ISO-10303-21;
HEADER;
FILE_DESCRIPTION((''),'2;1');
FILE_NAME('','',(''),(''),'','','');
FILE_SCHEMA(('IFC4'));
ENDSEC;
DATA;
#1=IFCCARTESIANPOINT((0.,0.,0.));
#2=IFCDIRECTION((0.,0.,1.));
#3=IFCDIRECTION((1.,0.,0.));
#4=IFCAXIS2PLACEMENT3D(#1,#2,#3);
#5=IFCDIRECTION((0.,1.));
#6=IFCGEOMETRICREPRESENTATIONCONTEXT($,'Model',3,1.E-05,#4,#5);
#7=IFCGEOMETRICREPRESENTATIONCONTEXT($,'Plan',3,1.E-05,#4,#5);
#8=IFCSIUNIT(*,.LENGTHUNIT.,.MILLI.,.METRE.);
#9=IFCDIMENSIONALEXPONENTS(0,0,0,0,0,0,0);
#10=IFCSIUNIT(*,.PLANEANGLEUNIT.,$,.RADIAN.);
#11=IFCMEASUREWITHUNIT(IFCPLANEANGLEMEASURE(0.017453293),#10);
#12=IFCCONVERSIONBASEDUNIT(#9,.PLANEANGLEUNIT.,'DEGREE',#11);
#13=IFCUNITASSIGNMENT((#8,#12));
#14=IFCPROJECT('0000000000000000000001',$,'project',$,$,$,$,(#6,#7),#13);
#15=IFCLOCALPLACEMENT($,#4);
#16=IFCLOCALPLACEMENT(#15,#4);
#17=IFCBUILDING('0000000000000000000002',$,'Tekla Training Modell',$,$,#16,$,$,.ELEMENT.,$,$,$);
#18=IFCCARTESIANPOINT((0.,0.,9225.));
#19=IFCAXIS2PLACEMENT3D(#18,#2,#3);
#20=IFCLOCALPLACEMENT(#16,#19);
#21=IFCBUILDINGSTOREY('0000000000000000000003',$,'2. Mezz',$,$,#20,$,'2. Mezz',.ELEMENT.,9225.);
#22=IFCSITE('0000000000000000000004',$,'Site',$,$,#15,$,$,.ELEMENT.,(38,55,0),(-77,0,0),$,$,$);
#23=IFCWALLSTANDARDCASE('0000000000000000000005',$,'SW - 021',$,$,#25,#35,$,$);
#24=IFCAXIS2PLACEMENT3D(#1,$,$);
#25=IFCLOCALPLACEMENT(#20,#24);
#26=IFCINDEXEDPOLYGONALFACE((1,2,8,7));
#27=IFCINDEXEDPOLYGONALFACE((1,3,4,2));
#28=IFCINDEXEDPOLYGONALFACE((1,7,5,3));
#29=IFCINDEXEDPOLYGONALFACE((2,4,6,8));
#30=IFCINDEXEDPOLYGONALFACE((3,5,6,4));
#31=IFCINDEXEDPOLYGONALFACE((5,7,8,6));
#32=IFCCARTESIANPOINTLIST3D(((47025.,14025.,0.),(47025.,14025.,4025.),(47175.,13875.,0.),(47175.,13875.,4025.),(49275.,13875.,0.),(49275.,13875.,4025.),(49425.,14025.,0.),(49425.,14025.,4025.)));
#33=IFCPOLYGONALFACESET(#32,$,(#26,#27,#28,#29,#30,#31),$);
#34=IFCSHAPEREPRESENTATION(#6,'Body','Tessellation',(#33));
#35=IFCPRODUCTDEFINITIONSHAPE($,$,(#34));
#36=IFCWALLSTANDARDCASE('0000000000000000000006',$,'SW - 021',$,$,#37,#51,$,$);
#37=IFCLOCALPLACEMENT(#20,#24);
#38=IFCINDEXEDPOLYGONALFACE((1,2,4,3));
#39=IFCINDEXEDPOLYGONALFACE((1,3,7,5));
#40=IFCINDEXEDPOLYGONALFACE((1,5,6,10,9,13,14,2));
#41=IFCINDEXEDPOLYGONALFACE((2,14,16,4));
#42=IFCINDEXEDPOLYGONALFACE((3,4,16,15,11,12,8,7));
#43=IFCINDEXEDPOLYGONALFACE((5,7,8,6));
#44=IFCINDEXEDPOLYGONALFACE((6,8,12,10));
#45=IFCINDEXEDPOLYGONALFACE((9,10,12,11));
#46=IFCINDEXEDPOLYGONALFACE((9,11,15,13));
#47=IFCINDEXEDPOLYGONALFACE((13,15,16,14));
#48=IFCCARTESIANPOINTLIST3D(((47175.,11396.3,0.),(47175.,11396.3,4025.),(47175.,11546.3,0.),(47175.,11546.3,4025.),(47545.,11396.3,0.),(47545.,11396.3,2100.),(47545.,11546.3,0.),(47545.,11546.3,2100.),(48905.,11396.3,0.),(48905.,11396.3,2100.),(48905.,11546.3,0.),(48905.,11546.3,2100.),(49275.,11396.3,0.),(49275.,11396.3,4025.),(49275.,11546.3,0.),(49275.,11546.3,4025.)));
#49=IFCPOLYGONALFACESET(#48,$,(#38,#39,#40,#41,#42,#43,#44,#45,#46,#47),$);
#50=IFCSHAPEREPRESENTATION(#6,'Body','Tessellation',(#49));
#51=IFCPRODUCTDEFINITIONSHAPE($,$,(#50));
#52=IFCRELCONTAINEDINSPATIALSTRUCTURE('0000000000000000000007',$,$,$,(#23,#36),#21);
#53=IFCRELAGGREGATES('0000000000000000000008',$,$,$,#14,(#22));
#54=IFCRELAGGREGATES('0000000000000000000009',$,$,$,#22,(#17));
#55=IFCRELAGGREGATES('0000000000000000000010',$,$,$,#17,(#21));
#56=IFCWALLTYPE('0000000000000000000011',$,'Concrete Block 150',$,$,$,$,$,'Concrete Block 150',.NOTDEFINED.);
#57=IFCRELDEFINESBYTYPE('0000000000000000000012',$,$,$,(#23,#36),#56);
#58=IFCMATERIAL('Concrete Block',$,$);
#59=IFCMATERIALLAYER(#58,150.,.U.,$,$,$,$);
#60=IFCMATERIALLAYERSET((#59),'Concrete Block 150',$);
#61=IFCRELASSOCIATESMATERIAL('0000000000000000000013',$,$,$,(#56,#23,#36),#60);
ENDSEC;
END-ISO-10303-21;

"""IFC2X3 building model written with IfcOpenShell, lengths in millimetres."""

from ifc_helpers import new_model, entity, si_unit, converted_unit, direction, frame, frame_2d, origin_with_axes, place, context, project, spatial, polyline, rectangle, outline, extrude, material, layer, layer_set, layer_usage, type_object, element, save


model = new_model("IFC2X3")

# Units and contexts
model_context = context("Model", 3, precision=1e-05, world=origin_with_axes(), true_north=direction((0.0, 1.0)))
plan_context = context("Plan", 3, precision=1e-05, world=origin_with_axes(), true_north=direction((0.0, 1.0)))
ifc_project = project(units=[si_unit("LENGTHUNIT", "METRE", prefix="MILLI"), converted_unit("PLANEANGLEUNIT", "DEGREE", entity("IfcPlaneAngleMeasure", 0.017453293), si_unit("PLANEANGLEUNIT", "RADIAN"), dimensions=[0, 0, 0, 0, 0, 0, 0])], contexts=[model_context, plan_context])

# Site, building, storey
site_placement = place(None, origin_with_axes())
site = spatial("IfcSite", under=ifc_project, at=site_placement, Name="Site", CompositionType="ELEMENT", RefLatitude=(38, 55, 0), RefLongitude=(-77, 0, 0))
building_placement = place(site_placement, origin_with_axes())
building = spatial("IfcBuilding", under=site, at=building_placement, Name="Tekla Training Modell", CompositionType="ELEMENT")
storey_placement = place(building_placement, frame((0.0, 0.0, 9225.0), z_axis=(0.0, 0.0, 1.0), x_axis=(1.0, 0.0, 0.0)))
storey = spatial("IfcBuildingStorey", under=building, at=storey_placement, Name="2. Mezz", LongName="2. Mezz", CompositionType="ELEMENT", Elevation=9225.0)

# Wall
ifc_material_1 = material(Name="Concrete Block")
ifc_layer_1 = layer(ifc_material_1, 150.0, ventilated="UNKNOWN")
ifc_layer_set_1 = layer_set([ifc_layer_1], Name="Concrete Block 150")
wall_type_1 = type_object("IfcWallType", Name="Concrete Block 150", ElementType="Concrete Block 150", PredefinedType="NOTDEFINED", material=ifc_layer_set_1)
ifc_layer_usage_1 = layer_usage(ifc_layer_set_1, "AXIS2", "NEGATIVE", 75.0)
wall_1_placement = place(storey_placement, frame((47100.0, 13950.0, 0.0), z_axis=(0.0, 0.0, 1.0), x_axis=(1.0, 0.0, 0.0)))
element("IfcWallStandardCase", 1, at=wall_1_placement, inside=storey, type_object=wall_type_1, material=ifc_layer_usage_1, Name="SW - 021", context=model_context, shape_type="SweptSolid", body=[
    extrude(outline(polyline([(75.0, -75.0), (2175.0, -75.0), (2325.0, 75.0), (-75.0, 75.0), (75.0, -75.0)])), origin_with_axes(), (0.0, 0.0, 1.0), 4025.0),
])

# Wall, opening
ifc_layer_usage_2 = layer_usage(ifc_layer_set_1, "AXIS2", "NEGATIVE", 75.0)
wall_2_placement = place(storey_placement, frame((49350.0, 11471.3, 0.0), z_axis=(0.0, 0.0, 1.0), x_axis=(-1.0, 0.0, 0.0)))
wall_2 = element("IfcWallStandardCase", 2, at=wall_2_placement, inside=storey, type_object=wall_type_1, material=ifc_layer_usage_2, Name="SW - 021", context=model_context, shape_type="SweptSolid", body=[
    extrude(outline(polyline([(75.0, -75.0), (2175.0, -75.0), (2175.0, 75.0), (75.0, 75.0), (75.0, -75.0)])), origin_with_axes(), (0.0, 0.0, 1.0), 4025.0),
])
opening_placement = place(wall_2_placement, frame((1125.0, -75.0, 0.0), z_axis=(0.0, 0.0, 1.0), x_axis=(1.0, 0.0, 0.0)))
element("IfcOpeningElement", 3, at=opening_placement, cuts=wall_2, ObjectType="Opening", context=model_context, shape_type="SweptSolid", body=[
    extrude(rectangle(XDim=1360.0, YDim=2100.0, at=frame_2d((0.0, 1050.0), x_axis=(-1.0, 0.0))), frame((0.0, 0.0, 0.0), z_axis=(0.0, 1.0, 0.0), x_axis=(-1.0, 0.0, 0.0)), (0.0, 0.0, 1.0), 150.0),
])

save(model, "model.ifc")
